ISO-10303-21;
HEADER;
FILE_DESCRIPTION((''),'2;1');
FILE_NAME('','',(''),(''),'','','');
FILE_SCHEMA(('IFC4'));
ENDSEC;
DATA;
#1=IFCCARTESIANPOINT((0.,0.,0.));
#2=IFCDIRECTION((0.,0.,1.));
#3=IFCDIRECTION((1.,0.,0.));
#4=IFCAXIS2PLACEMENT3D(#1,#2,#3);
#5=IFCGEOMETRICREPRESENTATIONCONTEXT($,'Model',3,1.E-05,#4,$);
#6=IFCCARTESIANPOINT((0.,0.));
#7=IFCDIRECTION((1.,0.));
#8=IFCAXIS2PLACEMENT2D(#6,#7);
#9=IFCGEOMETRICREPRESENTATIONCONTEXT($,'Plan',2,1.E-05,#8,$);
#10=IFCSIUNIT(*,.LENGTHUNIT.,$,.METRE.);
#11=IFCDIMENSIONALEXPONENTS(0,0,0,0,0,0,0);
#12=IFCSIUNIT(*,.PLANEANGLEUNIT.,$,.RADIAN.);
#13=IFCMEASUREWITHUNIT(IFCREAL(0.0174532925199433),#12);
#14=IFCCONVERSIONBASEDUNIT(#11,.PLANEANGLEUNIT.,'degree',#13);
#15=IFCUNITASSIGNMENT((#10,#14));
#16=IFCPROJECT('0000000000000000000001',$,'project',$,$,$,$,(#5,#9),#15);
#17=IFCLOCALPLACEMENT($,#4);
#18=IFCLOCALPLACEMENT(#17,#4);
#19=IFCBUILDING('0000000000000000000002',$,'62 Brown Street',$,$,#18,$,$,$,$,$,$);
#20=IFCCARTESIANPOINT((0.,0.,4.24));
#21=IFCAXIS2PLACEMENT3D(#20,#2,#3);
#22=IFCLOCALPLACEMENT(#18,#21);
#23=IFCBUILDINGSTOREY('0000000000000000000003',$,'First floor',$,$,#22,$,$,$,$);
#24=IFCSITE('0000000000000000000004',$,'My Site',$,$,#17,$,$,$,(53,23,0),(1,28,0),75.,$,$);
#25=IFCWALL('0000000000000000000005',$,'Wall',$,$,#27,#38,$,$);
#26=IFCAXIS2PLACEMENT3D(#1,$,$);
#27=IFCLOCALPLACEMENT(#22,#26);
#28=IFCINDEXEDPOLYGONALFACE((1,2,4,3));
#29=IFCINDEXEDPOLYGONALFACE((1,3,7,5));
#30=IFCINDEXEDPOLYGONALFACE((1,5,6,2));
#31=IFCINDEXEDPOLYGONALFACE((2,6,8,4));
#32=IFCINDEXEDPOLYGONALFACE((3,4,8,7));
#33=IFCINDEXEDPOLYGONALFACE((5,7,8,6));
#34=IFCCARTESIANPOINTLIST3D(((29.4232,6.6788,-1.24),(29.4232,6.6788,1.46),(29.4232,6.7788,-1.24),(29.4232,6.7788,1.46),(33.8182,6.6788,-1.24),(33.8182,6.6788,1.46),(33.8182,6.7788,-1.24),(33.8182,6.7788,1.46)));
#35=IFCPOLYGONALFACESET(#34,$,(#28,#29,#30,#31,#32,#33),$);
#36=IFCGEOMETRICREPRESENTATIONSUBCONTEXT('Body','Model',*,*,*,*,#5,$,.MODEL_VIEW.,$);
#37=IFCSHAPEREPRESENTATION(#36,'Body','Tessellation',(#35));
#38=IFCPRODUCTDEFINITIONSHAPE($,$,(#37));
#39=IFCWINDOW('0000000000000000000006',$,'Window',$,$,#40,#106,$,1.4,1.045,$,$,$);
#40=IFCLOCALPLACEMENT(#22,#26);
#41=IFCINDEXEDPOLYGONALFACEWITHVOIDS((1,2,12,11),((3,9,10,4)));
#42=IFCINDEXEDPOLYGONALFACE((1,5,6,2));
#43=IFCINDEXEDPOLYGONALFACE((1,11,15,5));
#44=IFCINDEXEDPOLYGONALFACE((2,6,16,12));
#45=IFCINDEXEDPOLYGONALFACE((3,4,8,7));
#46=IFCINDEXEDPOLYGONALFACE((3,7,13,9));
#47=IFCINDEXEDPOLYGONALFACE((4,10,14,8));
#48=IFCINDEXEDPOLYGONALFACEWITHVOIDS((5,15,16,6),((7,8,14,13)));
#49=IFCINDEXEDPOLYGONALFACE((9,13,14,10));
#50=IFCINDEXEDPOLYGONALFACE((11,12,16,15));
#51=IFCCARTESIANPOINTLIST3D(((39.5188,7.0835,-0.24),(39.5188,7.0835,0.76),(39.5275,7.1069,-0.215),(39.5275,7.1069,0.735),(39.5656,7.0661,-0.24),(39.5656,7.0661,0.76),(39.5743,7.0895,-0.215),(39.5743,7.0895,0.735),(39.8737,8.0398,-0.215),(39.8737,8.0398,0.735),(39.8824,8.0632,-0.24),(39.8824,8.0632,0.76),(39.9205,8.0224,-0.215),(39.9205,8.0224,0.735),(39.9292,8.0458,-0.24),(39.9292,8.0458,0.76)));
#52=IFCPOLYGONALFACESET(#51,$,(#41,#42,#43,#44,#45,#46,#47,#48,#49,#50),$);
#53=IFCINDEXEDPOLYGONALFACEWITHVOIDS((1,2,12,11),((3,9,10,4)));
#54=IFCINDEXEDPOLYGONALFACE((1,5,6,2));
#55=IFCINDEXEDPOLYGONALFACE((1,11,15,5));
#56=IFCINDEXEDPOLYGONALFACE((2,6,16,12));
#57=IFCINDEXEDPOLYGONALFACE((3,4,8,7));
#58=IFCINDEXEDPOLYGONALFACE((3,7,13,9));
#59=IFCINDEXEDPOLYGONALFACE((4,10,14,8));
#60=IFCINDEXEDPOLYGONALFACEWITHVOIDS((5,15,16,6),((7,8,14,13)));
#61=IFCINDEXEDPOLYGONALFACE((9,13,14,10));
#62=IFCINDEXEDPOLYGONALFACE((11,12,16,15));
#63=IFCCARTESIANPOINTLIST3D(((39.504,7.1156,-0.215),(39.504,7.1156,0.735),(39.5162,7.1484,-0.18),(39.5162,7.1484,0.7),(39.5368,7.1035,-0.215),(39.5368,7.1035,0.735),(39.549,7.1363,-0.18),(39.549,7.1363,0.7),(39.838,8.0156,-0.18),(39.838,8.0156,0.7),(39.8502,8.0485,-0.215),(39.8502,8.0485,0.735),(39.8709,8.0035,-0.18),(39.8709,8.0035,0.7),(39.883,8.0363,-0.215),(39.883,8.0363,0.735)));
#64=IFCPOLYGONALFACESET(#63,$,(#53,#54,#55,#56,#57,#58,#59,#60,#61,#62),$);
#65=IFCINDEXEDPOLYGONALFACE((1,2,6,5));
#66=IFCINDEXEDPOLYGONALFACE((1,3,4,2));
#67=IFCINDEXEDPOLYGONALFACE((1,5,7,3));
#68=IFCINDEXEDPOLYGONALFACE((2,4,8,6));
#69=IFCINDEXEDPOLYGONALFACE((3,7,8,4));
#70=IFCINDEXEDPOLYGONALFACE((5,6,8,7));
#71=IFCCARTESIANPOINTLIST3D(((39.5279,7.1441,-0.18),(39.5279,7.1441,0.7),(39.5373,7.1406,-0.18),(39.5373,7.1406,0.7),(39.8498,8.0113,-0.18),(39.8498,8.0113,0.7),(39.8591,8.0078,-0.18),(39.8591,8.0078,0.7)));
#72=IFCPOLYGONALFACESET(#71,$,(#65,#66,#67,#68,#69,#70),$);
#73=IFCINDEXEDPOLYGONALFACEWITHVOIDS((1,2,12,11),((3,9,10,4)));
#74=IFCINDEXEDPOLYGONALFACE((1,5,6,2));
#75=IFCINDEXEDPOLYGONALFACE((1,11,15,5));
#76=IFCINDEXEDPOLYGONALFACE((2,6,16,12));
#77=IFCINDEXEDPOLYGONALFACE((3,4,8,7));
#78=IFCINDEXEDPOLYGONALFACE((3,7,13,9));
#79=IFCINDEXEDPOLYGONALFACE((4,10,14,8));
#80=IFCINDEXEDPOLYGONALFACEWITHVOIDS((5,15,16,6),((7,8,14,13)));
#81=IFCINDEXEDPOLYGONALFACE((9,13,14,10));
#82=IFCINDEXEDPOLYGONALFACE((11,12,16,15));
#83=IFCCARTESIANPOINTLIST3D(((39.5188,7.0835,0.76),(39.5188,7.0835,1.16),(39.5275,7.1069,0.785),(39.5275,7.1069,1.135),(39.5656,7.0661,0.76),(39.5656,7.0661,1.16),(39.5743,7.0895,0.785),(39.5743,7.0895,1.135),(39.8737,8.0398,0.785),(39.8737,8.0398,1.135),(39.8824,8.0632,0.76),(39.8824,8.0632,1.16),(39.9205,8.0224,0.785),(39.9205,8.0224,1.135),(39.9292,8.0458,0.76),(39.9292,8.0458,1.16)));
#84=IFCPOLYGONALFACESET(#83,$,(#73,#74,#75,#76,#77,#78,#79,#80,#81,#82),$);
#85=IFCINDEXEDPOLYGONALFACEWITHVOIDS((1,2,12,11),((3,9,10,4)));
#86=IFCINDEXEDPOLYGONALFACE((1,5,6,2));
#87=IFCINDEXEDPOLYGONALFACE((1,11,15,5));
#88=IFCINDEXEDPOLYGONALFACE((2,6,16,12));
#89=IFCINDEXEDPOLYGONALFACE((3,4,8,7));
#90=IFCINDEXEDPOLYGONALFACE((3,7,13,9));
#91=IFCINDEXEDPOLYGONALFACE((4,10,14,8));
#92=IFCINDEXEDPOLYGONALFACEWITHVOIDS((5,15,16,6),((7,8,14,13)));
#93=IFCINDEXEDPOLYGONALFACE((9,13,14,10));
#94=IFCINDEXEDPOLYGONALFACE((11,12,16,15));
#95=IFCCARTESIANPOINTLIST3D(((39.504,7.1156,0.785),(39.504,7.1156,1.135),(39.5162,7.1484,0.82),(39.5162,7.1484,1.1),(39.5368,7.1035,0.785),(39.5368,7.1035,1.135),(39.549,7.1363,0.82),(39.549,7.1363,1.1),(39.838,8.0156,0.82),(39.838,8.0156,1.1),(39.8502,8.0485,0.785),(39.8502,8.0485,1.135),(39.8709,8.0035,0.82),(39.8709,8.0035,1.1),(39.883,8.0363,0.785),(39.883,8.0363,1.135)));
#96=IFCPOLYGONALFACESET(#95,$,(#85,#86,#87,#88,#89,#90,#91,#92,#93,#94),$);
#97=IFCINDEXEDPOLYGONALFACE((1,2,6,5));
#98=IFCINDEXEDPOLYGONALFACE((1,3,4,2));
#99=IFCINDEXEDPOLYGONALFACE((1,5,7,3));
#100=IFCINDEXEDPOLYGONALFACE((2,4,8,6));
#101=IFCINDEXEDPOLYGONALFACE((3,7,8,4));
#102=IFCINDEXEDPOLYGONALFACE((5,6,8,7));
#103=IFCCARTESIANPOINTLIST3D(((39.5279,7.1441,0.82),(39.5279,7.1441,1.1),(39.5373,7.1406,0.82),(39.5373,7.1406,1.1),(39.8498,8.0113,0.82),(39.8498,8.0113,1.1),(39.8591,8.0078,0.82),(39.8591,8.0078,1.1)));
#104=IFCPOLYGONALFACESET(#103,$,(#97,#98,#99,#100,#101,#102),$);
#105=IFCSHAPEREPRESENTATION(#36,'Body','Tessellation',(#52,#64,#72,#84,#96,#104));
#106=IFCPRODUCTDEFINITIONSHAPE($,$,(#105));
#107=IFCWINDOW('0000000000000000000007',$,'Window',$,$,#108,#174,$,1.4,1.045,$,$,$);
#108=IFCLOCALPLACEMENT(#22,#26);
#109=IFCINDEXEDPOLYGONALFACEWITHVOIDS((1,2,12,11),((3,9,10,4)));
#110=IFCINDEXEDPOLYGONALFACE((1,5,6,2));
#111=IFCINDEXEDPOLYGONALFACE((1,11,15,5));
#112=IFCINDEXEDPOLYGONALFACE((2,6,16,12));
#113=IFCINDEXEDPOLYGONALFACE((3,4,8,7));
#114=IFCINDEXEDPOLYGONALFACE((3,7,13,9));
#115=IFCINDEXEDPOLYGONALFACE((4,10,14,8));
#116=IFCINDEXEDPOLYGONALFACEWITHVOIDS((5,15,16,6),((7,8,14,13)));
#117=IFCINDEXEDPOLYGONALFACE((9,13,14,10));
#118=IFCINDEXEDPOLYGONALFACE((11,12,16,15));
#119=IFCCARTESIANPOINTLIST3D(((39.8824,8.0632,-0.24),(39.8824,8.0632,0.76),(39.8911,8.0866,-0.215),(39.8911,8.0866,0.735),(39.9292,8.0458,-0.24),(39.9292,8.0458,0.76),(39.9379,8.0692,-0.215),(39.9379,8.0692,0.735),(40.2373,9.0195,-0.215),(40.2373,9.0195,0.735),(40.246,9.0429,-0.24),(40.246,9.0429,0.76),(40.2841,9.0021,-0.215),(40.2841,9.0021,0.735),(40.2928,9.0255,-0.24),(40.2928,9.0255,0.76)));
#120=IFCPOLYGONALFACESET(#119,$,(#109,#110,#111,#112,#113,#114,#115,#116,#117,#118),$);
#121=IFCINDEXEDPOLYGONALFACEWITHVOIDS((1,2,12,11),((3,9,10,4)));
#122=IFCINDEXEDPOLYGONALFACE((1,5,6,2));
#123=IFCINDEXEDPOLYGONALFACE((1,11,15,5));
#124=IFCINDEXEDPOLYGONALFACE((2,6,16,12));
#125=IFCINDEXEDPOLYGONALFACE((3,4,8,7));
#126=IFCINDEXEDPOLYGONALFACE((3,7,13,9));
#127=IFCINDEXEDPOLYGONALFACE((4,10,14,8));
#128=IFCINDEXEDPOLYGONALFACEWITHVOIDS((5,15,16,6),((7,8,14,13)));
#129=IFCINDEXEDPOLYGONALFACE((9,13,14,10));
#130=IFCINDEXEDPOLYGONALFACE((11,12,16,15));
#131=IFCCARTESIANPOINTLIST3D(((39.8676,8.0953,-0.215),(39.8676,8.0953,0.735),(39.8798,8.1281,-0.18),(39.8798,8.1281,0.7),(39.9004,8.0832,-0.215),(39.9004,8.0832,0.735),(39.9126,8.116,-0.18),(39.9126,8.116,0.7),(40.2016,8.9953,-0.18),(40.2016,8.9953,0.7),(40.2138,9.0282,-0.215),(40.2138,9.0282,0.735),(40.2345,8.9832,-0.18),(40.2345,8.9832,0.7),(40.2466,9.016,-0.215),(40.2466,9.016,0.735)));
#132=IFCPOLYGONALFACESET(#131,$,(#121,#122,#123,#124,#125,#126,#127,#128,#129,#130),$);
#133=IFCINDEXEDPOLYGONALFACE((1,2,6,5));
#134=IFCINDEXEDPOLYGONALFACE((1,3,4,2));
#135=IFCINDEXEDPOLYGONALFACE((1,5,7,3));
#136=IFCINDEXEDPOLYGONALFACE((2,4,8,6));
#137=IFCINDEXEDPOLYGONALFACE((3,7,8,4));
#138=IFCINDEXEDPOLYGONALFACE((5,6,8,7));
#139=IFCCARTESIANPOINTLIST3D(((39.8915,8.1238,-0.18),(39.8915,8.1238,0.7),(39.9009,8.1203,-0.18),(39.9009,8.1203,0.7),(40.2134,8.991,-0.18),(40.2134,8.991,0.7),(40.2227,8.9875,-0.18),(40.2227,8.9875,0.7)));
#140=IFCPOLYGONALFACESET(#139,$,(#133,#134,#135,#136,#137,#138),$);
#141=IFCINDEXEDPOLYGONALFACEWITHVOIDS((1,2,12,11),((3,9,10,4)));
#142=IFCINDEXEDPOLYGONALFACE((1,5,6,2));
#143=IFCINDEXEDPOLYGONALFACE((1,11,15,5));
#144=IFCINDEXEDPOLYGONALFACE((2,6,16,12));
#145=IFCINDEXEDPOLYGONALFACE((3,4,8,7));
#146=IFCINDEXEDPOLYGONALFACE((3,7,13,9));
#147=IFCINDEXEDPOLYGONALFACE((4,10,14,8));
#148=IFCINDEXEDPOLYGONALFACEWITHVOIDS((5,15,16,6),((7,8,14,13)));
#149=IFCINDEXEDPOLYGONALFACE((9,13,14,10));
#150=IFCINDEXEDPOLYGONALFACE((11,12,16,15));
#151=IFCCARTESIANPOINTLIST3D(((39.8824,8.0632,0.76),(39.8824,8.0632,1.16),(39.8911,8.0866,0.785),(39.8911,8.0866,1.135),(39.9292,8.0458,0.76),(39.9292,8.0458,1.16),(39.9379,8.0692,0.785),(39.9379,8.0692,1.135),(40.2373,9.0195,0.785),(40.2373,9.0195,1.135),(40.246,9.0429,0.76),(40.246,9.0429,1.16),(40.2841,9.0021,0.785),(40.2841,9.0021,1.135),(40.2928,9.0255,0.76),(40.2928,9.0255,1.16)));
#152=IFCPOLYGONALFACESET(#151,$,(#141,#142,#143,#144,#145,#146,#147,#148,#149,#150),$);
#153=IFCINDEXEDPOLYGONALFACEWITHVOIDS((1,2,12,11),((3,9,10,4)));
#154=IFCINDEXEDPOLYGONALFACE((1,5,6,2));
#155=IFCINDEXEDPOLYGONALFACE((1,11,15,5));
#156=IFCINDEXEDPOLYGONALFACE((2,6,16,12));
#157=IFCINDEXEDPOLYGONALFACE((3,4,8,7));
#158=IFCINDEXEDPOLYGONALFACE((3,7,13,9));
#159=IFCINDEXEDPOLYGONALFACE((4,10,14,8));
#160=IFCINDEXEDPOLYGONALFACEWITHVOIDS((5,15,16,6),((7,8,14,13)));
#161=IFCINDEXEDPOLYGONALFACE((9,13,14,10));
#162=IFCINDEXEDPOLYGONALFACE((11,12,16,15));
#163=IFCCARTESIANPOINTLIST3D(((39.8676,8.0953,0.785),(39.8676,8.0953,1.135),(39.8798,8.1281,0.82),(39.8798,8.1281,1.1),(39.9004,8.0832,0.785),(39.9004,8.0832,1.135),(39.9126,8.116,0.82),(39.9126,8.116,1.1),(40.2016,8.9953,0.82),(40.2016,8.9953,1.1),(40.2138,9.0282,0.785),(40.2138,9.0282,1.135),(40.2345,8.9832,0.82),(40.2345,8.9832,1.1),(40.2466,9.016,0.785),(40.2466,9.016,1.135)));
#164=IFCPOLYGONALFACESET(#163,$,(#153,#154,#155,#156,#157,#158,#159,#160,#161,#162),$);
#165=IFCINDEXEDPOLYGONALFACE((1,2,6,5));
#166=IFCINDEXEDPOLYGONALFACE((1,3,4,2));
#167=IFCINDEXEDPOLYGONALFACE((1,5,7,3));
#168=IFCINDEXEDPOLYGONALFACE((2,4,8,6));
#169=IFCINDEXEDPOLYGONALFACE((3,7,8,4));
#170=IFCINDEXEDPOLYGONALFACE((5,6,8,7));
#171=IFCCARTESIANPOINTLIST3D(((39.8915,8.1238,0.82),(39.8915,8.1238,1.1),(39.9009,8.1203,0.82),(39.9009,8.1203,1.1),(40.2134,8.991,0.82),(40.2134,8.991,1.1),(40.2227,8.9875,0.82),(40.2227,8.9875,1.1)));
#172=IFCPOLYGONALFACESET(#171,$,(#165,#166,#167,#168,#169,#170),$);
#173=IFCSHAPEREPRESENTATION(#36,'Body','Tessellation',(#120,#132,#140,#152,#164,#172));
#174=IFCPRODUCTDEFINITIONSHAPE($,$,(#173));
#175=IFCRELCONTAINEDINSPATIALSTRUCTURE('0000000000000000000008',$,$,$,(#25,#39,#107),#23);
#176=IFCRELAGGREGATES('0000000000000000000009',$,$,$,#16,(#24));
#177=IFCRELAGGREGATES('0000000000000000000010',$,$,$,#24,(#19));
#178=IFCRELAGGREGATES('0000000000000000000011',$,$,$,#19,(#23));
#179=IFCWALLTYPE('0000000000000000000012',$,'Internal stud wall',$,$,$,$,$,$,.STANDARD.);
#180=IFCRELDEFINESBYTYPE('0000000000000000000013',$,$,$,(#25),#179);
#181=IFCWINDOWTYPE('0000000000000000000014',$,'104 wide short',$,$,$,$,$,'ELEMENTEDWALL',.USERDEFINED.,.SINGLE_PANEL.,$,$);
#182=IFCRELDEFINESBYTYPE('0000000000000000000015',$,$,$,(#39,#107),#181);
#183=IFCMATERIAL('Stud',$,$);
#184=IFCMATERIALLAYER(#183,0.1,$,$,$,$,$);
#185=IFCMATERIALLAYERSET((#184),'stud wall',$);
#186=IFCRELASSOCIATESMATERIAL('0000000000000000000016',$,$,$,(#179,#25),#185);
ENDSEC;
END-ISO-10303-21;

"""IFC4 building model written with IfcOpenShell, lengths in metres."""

from ifc_helpers import new_model, entity, si_unit, converted_unit, frame, origin_with_axes, origin_2d_with_axis, place, context, subcontext, project, spatial, line, indexed_curve, outline, extrude, shape, source, transform, mapped, material, layer, layer_set, layer_usage, type_object, type_shapes, element, save


model = new_model("IFC4")

# Units and contexts
model_context = context("Model", 3, precision=1e-05, world=origin_with_axes())
plan_context = context("Plan", 2, precision=1e-05, world=origin_2d_with_axis())
body_context_1 = subcontext(model_context, "Body", "Model", "MODEL_VIEW")
body_context_2 = subcontext(plan_context, "Body", "Plan", "PLAN_VIEW")
ifc_project = project(units=[si_unit("LENGTHUNIT", "METRE"), converted_unit("PLANEANGLEUNIT", "degree", entity("IfcReal", 0.0174532925199433), si_unit("PLANEANGLEUNIT", "RADIAN"), dimensions=[0, 0, 0, 0, 0, 0, 0])], contexts=[model_context, plan_context])

# Site, building, storey
site_placement = place(None, origin_with_axes())
site = spatial("IfcSite", under=ifc_project, at=site_placement, Name="My Site", RefLatitude=(53, 23, 0), RefLongitude=(1, 28, 0), RefElevation=75.0)
building_placement = place(site_placement, origin_with_axes())
building = spatial("IfcBuilding", under=site, at=building_placement, Name="62 Brown Street")
storey_placement = place(building_placement, frame((0.0, 0.0, 4.24), z_axis=(0.0, 0.0, 1.0), x_axis=(1.0, 0.0, 0.0)))
storey = spatial("IfcBuildingStorey", under=building, at=storey_placement, Name="First floor")

# Shared definitions
window_type_1 = type_object("IfcWindowType", Name="104 wide short", ElementType="ELEMENTEDWALL", PartitioningType="SINGLE_PANEL", PredefinedType="USERDEFINED")
shared_shape_1 = source(origin_with_axes(), body_context_1, "Body", "SweptSolid", [
    extrude(outline(indexed_curve([(0.0, 0.0), (1.045, 0.0), (1.045, 1.0), (0.0, 1.0)], segments=[line(1, 2, 3, 4, 1)]), holes=[indexed_curve([(0.025, 0.025), (1.02, 0.025), (1.02, 0.975), (0.025, 0.975)], segments=[line(1, 2, 3, 4, 1)])]), frame((0.0, 0.15, 0.0), z_axis=(0.0, -1.0, 0.0), x_axis=(1.0, 0.0, 0.0)), (0.0, 0.0, -1.0), 0.05),
    extrude(outline(indexed_curve([(0.0, 0.0), (0.995, 0.0), (0.995, 0.95), (0.0, 0.95)], segments=[line(1, 2, 3, 4, 1)]), holes=[indexed_curve([(0.035, 0.035), (0.96, 0.035), (0.96, 0.915), (0.035, 0.915)], segments=[line(1, 2, 3, 4, 1)])]), frame((0.025, 0.19, 0.025), z_axis=(0.0, -1.0, 0.0), x_axis=(1.0, 0.0, 0.0)), (0.0, 0.0, -1.0), 0.035),
    extrude(outline(indexed_curve([(0.035, 0.035), (0.96, 0.035), (0.96, 0.915), (0.035, 0.915)], segments=[line(1, 2, 3, 4, 1)])), frame((0.025, 0.2025, 0.025), z_axis=(0.0, -1.0, 0.0), x_axis=(1.0, 0.0, 0.0)), (0.0, 0.0, -1.0), 0.01),
    extrude(outline(indexed_curve([(0.0, 0.0), (1.045, 0.0), (1.045, 0.4), (0.0, 0.4)], segments=[line(1, 2, 3, 4, 1)]), holes=[indexed_curve([(0.025, 0.025), (1.02, 0.025), (1.02, 0.375), (0.025, 0.375)], segments=[line(1, 2, 3, 4, 1)])]), frame((0.0, 0.15, 1.0), z_axis=(0.0, -1.0, 0.0), x_axis=(1.0, 0.0, 0.0)), (0.0, 0.0, -1.0), 0.05),
    extrude(outline(indexed_curve([(0.0, 0.0), (0.995, 0.0), (0.995, 0.35), (0.0, 0.35)], segments=[line(1, 2, 3, 4, 1)]), holes=[indexed_curve([(0.035, 0.035), (0.96, 0.035), (0.96, 0.315), (0.035, 0.315)], segments=[line(1, 2, 3, 4, 1)])]), frame((0.025, 0.19, 1.025), z_axis=(0.0, -1.0, 0.0), x_axis=(1.0, 0.0, 0.0)), (0.0, 0.0, -1.0), 0.035),
    extrude(outline(indexed_curve([(0.035, 0.035), (0.96, 0.035), (0.96, 0.315), (0.035, 0.315)], segments=[line(1, 2, 3, 4, 1)])), frame((0.025, 0.2025, 1.025), z_axis=(0.0, -1.0, 0.0), x_axis=(1.0, 0.0, 0.0)), (0.0, 0.0, -1.0), 0.01),
])
shared_shape_2 = source(origin_with_axes(), body_context_2, "Body", "Curve2D", [
    entity("IfcIndexedPolyCurve", entity("IfcCartesianPointList2D", [[0.025, 0.15], [1.02, 0.15]])),
    entity("IfcIndexedPolyCurve", entity("IfcCartesianPointList2D", [[0.0, 0.2], [0.025, 0.2], [0.025, 0.15], [0.0, 0.15]]), [entity("IfcLineIndex", [1, 2, 3, 4, 1])]),
    entity("IfcIndexedPolyCurve", entity("IfcCartesianPointList2D", [[1.045, 0.2], [1.02, 0.2], [1.02, 0.15], [1.045, 0.15]]), [entity("IfcLineIndex", [1, 2, 3, 4, 1])]),
    entity("IfcIndexedPolyCurve", entity("IfcCartesianPointList2D", [[0.025, 0.19], [0.06, 0.19], [0.06, 0.225], [0.025, 0.225]]), [entity("IfcLineIndex", [1, 2, 3, 4, 1])]),
    entity("IfcIndexedPolyCurve", entity("IfcCartesianPointList2D", [[1.02, 0.19], [0.985, 0.19], [0.985, 0.225], [1.02, 0.225]]), [entity("IfcLineIndex", [1, 2, 3, 4, 1])]),
    entity("IfcIndexedPolyCurve", entity("IfcCartesianPointList2D", [[0.06, 0.19], [0.985, 0.19]])),
    entity("IfcIndexedPolyCurve", entity("IfcCartesianPointList2D", [[0.06, 0.225], [0.985, 0.225]])),
    entity("IfcIndexedPolyCurve", entity("IfcCartesianPointList2D", [[0.06, 0.2075], [0.985, 0.2075]])),
])
type_shapes(window_type_1, [shared_shape_1, shared_shape_2])

# Shared definitions
ifc_material_1 = material(Name="Stud")
ifc_layer_1 = layer(ifc_material_1, 0.1)
ifc_layer_set_1 = layer_set([ifc_layer_1], Name="stud wall")
wall_type_1 = type_object("IfcWallType", Name="Internal stud wall", PredefinedType="STANDARD", material=ifc_layer_set_1)

# Wall
ifc_layer_usage_1 = layer_usage(ifc_layer_set_1, "AXIS2", "POSITIVE", 0.0)
wall_1_placement = place(storey_placement, frame((33.8182, 6.7788, -1.24), z_axis=(0.0, 0.0, 1.0), x_axis=(-1.0, 0.000001, 0.0)))
element("IfcWall", 1, at=wall_1_placement, inside=storey, type_object=wall_type_1, material=ifc_layer_usage_1, Name="Wall", context=body_context_1, shape_type="SweptSolid", body=[
    extrude(outline(indexed_curve([(0.0, 0.0), (0.0, 0.1), (4.395, 0.1), (4.395, 0.0), (0.0, 0.0)], self_intersect=False)), origin_with_axes(), (0.0, 0.0, 1.0), 2.7),
])

# Windows
for number, where, z_axis, x_axis, name in (
    (2, (39.7063, 7.0139, -0.24), (0.0, 0.0, 1.0), (0.347944, 0.937515, 0.0), "Window"),
    (3, (40.0699, 7.9936, -0.24), (0.0, 0.0, 1.0), (0.347944, 0.937515, 0.0), "Window"),
):
    element("IfcWindow", number, at=place(storey_placement, frame(where, z_axis=z_axis, x_axis=x_axis)), inside=storey, type_object=window_type_1, Name=name, OverallHeight=1.4, OverallWidth=1.045, shapes=[
        shape(body_context_1, "Body", "MappedRepresentation", [mapped(shared_shape_1, transform((0.0, 0.0, 0.0), x_axis=(1.0, 0.0, 0.0), y_axis=(0.0, 1.0, 0.0), z_axis=(0.0, 0.0, 1.0), scale=1.0))]),
        shape(body_context_2, "Body", "MappedRepresentation", [mapped(shared_shape_2, transform((0.0, 0.0, 0.0), x_axis=(1.0, 0.0, 0.0), y_axis=(0.0, 1.0, 0.0), z_axis=(0.0, 0.0, 1.0), scale=1.0))]),
    ])

save(model, "model.ifc")
